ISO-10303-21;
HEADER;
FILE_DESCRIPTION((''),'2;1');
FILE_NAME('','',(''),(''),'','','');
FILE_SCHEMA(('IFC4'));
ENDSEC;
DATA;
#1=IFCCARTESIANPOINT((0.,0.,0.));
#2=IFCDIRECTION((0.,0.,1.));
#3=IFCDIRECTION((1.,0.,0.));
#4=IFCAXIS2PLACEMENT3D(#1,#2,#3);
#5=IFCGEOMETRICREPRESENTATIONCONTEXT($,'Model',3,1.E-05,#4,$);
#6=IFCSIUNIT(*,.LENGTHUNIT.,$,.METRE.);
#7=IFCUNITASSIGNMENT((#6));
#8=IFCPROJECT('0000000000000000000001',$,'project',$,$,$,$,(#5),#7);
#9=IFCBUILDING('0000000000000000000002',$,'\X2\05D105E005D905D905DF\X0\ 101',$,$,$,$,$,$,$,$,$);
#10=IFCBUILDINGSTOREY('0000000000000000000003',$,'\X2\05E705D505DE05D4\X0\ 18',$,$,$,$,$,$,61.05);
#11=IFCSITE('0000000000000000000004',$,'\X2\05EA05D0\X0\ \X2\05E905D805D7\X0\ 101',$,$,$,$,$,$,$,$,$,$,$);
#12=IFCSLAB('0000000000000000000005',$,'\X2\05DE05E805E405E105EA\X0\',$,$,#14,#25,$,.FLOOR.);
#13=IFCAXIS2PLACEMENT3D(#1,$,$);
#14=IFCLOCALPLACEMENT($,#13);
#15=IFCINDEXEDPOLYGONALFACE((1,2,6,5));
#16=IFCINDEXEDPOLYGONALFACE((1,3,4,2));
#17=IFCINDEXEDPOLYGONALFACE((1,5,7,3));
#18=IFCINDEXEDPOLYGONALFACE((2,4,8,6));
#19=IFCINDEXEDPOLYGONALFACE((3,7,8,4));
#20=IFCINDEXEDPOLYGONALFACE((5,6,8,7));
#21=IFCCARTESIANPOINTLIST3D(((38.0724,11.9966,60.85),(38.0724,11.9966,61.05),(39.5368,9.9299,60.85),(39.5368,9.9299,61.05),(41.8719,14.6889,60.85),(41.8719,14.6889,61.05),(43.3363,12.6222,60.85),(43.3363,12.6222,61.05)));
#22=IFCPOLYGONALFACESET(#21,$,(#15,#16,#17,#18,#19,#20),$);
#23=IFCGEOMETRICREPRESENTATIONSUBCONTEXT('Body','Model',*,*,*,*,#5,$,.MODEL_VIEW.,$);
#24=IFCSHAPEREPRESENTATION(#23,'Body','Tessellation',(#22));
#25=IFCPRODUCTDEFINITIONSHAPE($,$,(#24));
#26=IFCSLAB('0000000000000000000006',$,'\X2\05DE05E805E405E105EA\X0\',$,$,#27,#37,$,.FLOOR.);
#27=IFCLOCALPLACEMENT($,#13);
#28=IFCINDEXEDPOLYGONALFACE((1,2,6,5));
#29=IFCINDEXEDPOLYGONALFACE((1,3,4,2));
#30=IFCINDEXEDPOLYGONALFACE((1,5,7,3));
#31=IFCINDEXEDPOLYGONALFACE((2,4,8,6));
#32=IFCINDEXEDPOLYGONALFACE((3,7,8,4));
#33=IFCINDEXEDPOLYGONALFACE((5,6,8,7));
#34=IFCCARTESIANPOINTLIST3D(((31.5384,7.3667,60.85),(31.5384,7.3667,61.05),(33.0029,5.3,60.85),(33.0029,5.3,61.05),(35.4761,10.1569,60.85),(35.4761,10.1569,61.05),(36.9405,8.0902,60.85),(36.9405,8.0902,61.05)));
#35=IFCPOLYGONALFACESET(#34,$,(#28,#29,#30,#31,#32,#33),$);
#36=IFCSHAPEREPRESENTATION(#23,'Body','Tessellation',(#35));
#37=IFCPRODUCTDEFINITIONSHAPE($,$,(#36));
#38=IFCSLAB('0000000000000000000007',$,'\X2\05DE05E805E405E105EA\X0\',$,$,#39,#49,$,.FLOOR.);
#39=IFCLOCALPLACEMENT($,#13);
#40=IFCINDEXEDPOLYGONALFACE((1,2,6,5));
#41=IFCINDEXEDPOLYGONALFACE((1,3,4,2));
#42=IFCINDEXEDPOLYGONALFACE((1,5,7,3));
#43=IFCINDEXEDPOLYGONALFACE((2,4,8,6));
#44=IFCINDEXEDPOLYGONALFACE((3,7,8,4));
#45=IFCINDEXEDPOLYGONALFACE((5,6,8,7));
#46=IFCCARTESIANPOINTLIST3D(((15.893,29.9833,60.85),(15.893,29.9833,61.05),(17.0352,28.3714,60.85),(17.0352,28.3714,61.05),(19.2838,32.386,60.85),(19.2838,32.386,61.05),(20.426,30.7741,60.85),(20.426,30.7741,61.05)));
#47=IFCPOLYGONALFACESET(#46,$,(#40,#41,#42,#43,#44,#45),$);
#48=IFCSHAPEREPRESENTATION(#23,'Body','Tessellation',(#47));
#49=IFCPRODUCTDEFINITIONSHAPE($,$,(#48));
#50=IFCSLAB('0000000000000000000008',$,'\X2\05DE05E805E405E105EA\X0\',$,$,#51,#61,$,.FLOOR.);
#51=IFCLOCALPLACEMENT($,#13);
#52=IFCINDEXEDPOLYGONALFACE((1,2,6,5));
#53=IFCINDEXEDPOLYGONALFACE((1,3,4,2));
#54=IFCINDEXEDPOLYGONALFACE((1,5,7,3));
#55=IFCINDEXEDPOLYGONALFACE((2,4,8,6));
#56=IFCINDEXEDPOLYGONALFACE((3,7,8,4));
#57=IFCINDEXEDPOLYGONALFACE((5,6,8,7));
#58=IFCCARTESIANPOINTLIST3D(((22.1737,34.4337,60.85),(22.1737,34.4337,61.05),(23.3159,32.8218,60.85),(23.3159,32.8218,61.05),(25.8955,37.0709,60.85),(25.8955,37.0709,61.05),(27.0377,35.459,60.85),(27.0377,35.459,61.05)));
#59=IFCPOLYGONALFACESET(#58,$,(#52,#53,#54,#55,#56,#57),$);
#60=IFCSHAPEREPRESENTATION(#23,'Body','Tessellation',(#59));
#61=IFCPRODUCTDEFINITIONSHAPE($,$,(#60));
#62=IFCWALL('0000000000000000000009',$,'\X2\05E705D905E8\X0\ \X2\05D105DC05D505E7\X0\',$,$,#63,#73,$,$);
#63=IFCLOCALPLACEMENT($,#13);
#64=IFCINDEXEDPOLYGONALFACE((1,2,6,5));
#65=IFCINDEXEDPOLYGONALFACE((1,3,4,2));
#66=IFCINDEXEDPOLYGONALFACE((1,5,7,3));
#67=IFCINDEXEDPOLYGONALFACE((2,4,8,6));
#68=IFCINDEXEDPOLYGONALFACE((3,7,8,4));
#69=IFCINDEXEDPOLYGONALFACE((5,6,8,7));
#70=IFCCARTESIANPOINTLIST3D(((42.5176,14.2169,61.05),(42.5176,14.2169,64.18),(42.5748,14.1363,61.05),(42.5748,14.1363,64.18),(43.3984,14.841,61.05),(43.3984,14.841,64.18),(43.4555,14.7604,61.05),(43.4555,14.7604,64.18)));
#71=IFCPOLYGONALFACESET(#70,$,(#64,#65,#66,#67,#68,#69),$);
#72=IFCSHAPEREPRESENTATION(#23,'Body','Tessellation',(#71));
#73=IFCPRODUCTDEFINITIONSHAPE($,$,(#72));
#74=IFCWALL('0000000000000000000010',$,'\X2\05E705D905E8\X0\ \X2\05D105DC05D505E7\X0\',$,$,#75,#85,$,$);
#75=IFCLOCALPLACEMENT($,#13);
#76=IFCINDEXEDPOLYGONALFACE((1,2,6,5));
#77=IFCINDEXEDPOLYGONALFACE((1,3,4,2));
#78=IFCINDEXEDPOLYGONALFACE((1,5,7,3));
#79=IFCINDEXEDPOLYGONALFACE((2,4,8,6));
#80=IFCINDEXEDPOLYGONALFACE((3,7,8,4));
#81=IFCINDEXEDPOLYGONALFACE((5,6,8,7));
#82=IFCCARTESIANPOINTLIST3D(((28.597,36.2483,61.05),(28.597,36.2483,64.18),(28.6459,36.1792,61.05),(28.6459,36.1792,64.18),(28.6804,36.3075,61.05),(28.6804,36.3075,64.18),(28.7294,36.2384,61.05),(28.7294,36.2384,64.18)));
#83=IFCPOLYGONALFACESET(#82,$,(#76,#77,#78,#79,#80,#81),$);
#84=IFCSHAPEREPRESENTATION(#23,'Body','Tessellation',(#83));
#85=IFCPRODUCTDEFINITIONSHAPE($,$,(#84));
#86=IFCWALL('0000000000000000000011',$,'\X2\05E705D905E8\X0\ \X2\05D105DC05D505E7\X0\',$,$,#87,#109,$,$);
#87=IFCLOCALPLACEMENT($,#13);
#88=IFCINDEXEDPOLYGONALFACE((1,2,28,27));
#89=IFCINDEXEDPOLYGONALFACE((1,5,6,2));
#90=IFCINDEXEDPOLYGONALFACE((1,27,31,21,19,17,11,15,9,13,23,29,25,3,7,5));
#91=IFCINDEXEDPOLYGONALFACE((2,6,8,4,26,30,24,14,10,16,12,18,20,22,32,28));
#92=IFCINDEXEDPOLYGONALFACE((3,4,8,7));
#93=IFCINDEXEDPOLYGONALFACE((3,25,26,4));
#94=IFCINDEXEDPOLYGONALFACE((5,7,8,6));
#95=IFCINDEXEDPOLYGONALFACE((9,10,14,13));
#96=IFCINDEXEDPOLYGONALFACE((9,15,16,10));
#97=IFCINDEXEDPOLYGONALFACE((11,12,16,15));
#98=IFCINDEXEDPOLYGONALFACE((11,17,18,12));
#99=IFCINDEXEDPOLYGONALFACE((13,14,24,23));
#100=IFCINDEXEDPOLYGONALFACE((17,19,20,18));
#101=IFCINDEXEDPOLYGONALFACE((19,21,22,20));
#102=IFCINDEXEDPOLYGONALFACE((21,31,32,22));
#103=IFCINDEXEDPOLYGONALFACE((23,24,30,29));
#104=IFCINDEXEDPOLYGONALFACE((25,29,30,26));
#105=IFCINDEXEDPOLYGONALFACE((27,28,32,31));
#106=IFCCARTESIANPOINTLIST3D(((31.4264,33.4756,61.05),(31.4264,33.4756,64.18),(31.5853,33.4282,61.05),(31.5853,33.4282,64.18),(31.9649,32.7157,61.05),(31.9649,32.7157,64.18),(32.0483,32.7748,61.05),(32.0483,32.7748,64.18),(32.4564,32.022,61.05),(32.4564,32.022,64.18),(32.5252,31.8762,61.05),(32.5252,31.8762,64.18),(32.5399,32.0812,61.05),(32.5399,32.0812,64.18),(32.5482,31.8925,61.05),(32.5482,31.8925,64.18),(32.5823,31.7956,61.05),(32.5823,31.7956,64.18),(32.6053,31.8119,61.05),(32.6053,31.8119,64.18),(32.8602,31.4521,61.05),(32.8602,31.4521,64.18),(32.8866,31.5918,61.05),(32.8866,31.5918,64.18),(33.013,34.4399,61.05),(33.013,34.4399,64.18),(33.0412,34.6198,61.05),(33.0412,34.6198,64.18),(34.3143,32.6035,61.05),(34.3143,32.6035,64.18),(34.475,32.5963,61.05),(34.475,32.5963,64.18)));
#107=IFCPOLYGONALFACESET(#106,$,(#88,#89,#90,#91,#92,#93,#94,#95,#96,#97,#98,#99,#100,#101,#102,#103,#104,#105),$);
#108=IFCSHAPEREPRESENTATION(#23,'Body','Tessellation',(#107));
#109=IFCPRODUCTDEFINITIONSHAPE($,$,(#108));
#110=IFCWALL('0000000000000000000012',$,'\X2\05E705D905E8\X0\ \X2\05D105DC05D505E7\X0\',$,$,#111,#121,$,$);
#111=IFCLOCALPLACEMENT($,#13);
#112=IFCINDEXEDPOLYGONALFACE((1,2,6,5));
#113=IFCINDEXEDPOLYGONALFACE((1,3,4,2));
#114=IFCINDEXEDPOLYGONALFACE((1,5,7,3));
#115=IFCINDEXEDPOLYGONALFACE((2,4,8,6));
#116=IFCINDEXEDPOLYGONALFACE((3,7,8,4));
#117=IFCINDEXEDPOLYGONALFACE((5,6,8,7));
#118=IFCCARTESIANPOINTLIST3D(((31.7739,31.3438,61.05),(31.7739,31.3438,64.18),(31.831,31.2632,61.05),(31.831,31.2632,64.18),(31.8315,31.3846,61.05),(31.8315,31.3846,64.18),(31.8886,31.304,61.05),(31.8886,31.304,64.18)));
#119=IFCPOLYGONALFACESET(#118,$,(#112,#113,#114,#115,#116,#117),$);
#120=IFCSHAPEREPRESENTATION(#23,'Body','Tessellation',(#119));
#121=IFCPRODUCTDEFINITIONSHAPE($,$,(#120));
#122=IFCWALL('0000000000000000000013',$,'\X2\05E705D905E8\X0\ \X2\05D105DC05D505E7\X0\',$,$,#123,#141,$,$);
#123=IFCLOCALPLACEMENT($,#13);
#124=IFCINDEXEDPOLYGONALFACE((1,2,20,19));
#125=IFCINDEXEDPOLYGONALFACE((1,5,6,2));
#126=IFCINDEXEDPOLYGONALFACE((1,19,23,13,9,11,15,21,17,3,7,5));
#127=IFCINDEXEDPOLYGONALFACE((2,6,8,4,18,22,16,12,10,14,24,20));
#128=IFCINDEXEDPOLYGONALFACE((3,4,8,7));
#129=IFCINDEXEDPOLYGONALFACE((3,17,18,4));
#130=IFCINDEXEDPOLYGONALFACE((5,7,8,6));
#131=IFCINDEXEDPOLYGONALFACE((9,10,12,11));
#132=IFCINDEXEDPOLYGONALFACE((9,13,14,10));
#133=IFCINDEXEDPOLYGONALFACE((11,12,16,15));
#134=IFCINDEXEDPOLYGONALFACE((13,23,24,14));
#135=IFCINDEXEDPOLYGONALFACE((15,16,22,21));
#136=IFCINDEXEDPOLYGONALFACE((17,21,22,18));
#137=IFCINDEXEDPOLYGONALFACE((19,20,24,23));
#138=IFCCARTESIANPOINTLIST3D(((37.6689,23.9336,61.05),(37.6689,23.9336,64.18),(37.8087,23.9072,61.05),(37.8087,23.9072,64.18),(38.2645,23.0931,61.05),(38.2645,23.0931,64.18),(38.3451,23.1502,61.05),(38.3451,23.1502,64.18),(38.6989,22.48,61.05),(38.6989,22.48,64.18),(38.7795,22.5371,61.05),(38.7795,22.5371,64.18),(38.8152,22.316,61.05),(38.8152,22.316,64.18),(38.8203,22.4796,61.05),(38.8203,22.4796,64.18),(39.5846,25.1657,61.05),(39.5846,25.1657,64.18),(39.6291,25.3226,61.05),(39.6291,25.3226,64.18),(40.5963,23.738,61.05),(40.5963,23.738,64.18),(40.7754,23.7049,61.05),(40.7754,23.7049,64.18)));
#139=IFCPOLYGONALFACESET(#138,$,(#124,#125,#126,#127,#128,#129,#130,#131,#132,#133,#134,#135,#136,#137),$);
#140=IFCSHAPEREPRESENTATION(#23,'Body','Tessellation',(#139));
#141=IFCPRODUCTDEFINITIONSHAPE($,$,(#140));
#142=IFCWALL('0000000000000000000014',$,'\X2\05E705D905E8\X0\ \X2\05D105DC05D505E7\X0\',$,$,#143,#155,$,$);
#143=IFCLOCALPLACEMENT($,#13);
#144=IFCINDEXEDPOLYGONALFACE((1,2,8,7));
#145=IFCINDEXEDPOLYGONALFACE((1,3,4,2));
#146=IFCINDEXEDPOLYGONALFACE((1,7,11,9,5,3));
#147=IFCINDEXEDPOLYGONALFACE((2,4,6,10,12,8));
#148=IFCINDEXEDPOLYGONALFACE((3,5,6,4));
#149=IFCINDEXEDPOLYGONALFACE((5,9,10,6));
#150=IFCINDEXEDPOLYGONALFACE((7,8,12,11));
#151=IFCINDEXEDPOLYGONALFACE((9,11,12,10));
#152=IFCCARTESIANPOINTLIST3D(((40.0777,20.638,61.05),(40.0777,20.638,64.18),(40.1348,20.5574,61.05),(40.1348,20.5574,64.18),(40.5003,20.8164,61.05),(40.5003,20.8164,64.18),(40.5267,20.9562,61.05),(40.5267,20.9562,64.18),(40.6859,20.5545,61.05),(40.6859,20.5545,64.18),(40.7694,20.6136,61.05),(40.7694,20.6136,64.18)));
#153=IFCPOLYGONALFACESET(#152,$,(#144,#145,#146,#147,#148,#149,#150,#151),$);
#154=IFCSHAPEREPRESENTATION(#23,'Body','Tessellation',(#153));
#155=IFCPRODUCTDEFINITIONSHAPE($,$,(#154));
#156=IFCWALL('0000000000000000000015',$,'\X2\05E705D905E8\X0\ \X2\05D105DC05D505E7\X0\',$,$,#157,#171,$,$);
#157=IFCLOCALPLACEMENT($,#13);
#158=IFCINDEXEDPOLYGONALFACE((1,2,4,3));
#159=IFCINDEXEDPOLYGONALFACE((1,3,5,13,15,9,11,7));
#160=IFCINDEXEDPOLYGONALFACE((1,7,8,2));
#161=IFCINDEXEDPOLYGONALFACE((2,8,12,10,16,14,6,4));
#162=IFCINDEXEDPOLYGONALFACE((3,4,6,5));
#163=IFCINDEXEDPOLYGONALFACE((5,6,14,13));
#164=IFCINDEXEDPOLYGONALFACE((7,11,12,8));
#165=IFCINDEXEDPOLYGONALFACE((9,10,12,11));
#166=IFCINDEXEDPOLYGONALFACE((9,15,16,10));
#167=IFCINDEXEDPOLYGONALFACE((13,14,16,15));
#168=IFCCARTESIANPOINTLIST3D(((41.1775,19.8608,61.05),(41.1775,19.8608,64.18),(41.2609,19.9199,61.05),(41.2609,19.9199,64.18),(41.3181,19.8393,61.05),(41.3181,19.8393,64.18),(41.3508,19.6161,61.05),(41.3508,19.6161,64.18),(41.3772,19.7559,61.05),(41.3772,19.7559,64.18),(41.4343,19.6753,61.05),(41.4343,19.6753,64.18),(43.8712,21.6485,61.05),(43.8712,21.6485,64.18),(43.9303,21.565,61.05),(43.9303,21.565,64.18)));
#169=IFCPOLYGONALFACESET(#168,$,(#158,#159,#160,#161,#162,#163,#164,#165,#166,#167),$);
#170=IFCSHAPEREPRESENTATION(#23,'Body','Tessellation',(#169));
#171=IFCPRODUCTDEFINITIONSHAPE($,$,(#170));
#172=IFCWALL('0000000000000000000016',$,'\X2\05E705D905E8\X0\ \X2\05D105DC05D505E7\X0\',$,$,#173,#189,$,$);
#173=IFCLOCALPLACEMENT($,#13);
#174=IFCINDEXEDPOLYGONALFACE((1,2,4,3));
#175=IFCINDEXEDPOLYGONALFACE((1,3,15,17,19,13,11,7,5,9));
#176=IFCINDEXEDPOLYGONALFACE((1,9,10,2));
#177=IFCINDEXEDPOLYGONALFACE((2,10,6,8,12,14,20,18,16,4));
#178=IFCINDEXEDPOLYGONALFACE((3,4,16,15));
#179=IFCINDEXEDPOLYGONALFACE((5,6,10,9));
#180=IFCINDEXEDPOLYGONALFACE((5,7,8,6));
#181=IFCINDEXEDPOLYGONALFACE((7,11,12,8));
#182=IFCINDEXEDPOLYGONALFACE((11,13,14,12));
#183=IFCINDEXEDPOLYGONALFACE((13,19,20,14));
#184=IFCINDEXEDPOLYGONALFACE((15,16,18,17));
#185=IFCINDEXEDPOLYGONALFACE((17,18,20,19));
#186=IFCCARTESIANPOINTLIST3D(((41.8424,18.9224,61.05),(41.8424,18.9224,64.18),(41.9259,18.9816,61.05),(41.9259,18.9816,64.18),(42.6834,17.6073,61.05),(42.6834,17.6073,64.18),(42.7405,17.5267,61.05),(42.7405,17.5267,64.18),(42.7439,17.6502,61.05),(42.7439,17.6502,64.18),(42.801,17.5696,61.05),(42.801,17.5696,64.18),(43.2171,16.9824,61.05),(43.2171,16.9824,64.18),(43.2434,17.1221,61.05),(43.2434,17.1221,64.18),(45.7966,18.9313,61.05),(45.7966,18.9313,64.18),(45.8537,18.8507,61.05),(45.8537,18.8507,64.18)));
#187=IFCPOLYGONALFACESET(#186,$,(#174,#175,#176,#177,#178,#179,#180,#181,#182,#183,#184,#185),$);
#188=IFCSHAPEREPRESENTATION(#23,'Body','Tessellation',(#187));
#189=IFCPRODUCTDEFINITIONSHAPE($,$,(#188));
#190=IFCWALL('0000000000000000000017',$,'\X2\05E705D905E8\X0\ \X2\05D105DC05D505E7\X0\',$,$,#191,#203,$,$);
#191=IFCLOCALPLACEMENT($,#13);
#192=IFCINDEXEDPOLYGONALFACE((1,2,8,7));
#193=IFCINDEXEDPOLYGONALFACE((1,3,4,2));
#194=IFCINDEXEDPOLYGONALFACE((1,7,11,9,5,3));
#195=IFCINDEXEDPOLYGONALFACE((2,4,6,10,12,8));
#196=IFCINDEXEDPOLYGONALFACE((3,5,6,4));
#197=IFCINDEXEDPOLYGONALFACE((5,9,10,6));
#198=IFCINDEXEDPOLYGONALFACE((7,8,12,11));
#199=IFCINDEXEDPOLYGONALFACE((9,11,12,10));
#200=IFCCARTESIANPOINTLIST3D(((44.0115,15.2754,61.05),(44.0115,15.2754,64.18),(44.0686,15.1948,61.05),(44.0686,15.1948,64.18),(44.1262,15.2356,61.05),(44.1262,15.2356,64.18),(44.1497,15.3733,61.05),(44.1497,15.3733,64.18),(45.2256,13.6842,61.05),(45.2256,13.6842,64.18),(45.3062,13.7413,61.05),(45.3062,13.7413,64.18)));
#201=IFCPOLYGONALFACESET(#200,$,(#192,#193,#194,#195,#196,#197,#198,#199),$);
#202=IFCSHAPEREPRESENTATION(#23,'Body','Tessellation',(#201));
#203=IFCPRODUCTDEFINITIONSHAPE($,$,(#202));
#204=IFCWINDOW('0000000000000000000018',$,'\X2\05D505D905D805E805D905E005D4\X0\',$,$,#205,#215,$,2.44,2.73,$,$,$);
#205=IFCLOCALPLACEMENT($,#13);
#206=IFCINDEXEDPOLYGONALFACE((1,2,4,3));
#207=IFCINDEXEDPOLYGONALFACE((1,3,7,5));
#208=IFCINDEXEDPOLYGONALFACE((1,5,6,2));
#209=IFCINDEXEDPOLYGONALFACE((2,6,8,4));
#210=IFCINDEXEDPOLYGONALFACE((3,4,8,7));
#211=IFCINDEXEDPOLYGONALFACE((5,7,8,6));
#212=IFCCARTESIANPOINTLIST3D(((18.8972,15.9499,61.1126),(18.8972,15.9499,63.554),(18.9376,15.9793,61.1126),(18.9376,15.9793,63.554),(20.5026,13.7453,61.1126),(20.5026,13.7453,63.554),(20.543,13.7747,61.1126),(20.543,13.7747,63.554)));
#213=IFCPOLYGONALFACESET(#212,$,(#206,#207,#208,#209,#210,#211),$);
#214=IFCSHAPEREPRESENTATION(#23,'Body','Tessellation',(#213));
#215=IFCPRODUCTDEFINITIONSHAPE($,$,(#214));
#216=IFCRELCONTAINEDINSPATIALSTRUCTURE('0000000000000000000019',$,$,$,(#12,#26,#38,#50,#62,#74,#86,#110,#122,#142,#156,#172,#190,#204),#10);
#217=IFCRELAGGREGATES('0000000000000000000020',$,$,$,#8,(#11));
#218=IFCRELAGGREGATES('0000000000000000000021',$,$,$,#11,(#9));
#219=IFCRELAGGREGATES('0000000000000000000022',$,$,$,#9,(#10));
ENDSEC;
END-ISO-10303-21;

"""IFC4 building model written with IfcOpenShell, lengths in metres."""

from ifc_helpers import new_model, si_unit, frame, origin_with_axes, context, subcontext, project, spatial, polyline, outline, extrude, element, save


model = new_model("IFC4")

# Units and contexts
model_context = context("Model", 3, precision=1e-05, world=origin_with_axes())
body_context = subcontext(model_context, "Body", "Model", "MODEL_VIEW")
ifc_project = project(units=[si_unit("LENGTHUNIT", "METRE")], contexts=[model_context])

# Site, building, storey
site = spatial("IfcSite", under=ifc_project, Name="תא שטח 101")
building = spatial("IfcBuilding", under=site, Name="בניין 101")
storey = spatial("IfcBuildingStorey", under=building, Name="קומה 18", Elevation=61.05)

# Slabs
element("IfcSlab", 1, inside=storey, Name="מרפסת", PredefinedType="FLOOR", context=body_context, shape_type="SweptSolid", body=[
    extrude(outline(polyline([(38.0724, 11.9966), (41.8719, 14.6889), (43.3363, 12.6222), (39.5368, 9.9299), (38.0724, 11.9966)])), frame((0.0, 0.0, 60.85)), (0.0, 0.0, 1.0), 0.2),
])
element("IfcSlab", 2, inside=storey, Name="מרפסת", PredefinedType="FLOOR", context=body_context, shape_type="SweptSolid", body=[
    extrude(outline(polyline([(31.5384, 7.3667), (35.4761, 10.1569), (36.9405, 8.0902), (33.0029, 5.3), (31.5384, 7.3667)])), frame((0.0, 0.0, 60.85)), (0.0, 0.0, 1.0), 0.2),
])
element("IfcSlab", 3, inside=storey, Name="מרפסת", PredefinedType="FLOOR", context=body_context, shape_type="SweptSolid", body=[
    extrude(outline(polyline([(15.893, 29.9833), (19.2838, 32.386), (20.426, 30.7741), (17.0352, 28.3714), (15.893, 29.9833)])), frame((0.0, 0.0, 60.85)), (0.0, 0.0, 1.0), 0.2),
])
element("IfcSlab", 4, inside=storey, Name="מרפסת", PredefinedType="FLOOR", context=body_context, shape_type="SweptSolid", body=[
    extrude(outline(polyline([(22.1737, 34.4337), (25.8955, 37.0709), (27.0377, 35.459), (23.3159, 32.8218), (22.1737, 34.4337)])), frame((0.0, 0.0, 60.85)), (0.0, 0.0, 1.0), 0.2),
])

# Walls
element("IfcWall", 5, inside=storey, Name="קיר בלוק", context=body_context, shape_type="SweptSolid", body=[
    extrude(outline(polyline([(42.5176, 14.2169), (42.5748, 14.1363), (43.4555, 14.7604), (43.3984, 14.841), (42.5176, 14.2169)])), frame((0.0, 0.0, 61.05)), (0.0, 0.0, 1.0), 3.13),
])
element("IfcWall", 6, inside=storey, Name="קיר בלוק", context=body_context, shape_type="SweptSolid", body=[
    extrude(outline(polyline([(28.7294, 36.2384), (28.6804, 36.3075), (28.597, 36.2483), (28.6459, 36.1792), (28.7294, 36.2384)])), frame((0.0, 0.0, 61.05)), (0.0, 0.0, 1.0), 3.13),
])
element("IfcWall", 7, inside=storey, Name="קיר בלוק", context=body_context, shape_type="SweptSolid", body=[
    extrude(outline(polyline([(31.5853, 33.4282), (33.013, 34.4399), (34.3143, 32.6035), (32.8866, 31.5918), (32.5399, 32.0812), (32.4564, 32.022), (32.5482, 31.8925), (32.5252, 31.8762), (32.5823, 31.7956), (32.6053, 31.8119), (32.8602, 31.4521), (34.475, 32.5963), (33.0412, 34.6198), (31.4264, 33.4756), (31.9649, 32.7157), (32.0483, 32.7748), (31.5853, 33.4282)])), frame((0.0, 0.0, 61.05)), (0.0, 0.0, 1.0), 3.13),
])
element("IfcWall", 8, inside=storey, Name="קיר בלוק", context=body_context, shape_type="SweptSolid", body=[
    extrude(outline(polyline([(31.7739, 31.3438), (31.831, 31.2632), (31.8886, 31.304), (31.8315, 31.3846), (31.7739, 31.3438)])), frame((0.0, 0.0, 61.05)), (0.0, 0.0, 1.0), 3.13),
])
element("IfcWall", 9, inside=storey, Name="קיר בלוק", context=body_context, shape_type="SweptSolid", body=[
    extrude(outline(polyline([(38.3451, 23.1502), (37.8087, 23.9072), (39.5846, 25.1657), (40.5963, 23.738), (38.8203, 22.4796), (38.7795, 22.5371), (38.6989, 22.48), (38.8152, 22.316), (40.7754, 23.7049), (39.6291, 25.3226), (37.6689, 23.9336), (38.2645, 23.0931), (38.3451, 23.1502)])), frame((0.0, 0.0, 61.05)), (0.0, 0.0, 1.0), 3.13),
])
element("IfcWall", 10, inside=storey, Name="קיר בלוק", context=body_context, shape_type="SweptSolid", body=[
    extrude(outline(polyline([(40.7694, 20.6136), (40.5267, 20.9562), (40.0777, 20.638), (40.1348, 20.5574), (40.5003, 20.8164), (40.6859, 20.5545), (40.7694, 20.6136)])), frame((0.0, 0.0, 61.05)), (0.0, 0.0, 1.0), 3.13),
])
element("IfcWall", 11, inside=storey, Name="קיר בלוק", context=body_context, shape_type="SweptSolid", body=[
    extrude(outline(polyline([(41.3772, 19.7559), (43.9303, 21.565), (43.8712, 21.6485), (41.3181, 19.8393), (41.2609, 19.9199), (41.1775, 19.8608), (41.3508, 19.6161), (41.4343, 19.6753), (41.3772, 19.7559)])), frame((0.0, 0.0, 61.05)), (0.0, 0.0, 1.0), 3.13),
])
element("IfcWall", 12, inside=storey, Name="קיר בלוק", context=body_context, shape_type="SweptSolid", body=[
    extrude(outline(polyline([(42.801, 17.5696), (43.2171, 16.9824), (45.8537, 18.8507), (45.7966, 18.9313), (43.2434, 17.1221), (41.9259, 18.9816), (41.8424, 18.9224), (42.7439, 17.6502), (42.6834, 17.6073), (42.7405, 17.5267), (42.801, 17.5696)])), frame((0.0, 0.0, 61.05)), (0.0, 0.0, 1.0), 3.13),
])
element("IfcWall", 13, inside=storey, Name="קיר בלוק", context=body_context, shape_type="SweptSolid", body=[
    extrude(outline(polyline([(44.1497, 15.3733), (44.0115, 15.2754), (44.0686, 15.1948), (44.1262, 15.2356), (45.2256, 13.6842), (45.3062, 13.7413), (44.1497, 15.3733)])), frame((0.0, 0.0, 61.05)), (0.0, 0.0, 1.0), 3.13),
])

# Window
element("IfcWindow", 14, inside=storey, Name="ויטרינה", OverallHeight=2.44, OverallWidth=2.73, context=body_context, shape_type="SweptSolid", body=[
    extrude(outline(polyline([(18.8972, 15.9499), (20.5026, 13.7453), (20.543, 13.7747), (18.9376, 15.9793), (18.8972, 15.9499)])), frame((0.0, 0.0, 61.1126)), (0.0, 0.0, 1.0), 2.4414),
])

save(model, "model.ifc")
